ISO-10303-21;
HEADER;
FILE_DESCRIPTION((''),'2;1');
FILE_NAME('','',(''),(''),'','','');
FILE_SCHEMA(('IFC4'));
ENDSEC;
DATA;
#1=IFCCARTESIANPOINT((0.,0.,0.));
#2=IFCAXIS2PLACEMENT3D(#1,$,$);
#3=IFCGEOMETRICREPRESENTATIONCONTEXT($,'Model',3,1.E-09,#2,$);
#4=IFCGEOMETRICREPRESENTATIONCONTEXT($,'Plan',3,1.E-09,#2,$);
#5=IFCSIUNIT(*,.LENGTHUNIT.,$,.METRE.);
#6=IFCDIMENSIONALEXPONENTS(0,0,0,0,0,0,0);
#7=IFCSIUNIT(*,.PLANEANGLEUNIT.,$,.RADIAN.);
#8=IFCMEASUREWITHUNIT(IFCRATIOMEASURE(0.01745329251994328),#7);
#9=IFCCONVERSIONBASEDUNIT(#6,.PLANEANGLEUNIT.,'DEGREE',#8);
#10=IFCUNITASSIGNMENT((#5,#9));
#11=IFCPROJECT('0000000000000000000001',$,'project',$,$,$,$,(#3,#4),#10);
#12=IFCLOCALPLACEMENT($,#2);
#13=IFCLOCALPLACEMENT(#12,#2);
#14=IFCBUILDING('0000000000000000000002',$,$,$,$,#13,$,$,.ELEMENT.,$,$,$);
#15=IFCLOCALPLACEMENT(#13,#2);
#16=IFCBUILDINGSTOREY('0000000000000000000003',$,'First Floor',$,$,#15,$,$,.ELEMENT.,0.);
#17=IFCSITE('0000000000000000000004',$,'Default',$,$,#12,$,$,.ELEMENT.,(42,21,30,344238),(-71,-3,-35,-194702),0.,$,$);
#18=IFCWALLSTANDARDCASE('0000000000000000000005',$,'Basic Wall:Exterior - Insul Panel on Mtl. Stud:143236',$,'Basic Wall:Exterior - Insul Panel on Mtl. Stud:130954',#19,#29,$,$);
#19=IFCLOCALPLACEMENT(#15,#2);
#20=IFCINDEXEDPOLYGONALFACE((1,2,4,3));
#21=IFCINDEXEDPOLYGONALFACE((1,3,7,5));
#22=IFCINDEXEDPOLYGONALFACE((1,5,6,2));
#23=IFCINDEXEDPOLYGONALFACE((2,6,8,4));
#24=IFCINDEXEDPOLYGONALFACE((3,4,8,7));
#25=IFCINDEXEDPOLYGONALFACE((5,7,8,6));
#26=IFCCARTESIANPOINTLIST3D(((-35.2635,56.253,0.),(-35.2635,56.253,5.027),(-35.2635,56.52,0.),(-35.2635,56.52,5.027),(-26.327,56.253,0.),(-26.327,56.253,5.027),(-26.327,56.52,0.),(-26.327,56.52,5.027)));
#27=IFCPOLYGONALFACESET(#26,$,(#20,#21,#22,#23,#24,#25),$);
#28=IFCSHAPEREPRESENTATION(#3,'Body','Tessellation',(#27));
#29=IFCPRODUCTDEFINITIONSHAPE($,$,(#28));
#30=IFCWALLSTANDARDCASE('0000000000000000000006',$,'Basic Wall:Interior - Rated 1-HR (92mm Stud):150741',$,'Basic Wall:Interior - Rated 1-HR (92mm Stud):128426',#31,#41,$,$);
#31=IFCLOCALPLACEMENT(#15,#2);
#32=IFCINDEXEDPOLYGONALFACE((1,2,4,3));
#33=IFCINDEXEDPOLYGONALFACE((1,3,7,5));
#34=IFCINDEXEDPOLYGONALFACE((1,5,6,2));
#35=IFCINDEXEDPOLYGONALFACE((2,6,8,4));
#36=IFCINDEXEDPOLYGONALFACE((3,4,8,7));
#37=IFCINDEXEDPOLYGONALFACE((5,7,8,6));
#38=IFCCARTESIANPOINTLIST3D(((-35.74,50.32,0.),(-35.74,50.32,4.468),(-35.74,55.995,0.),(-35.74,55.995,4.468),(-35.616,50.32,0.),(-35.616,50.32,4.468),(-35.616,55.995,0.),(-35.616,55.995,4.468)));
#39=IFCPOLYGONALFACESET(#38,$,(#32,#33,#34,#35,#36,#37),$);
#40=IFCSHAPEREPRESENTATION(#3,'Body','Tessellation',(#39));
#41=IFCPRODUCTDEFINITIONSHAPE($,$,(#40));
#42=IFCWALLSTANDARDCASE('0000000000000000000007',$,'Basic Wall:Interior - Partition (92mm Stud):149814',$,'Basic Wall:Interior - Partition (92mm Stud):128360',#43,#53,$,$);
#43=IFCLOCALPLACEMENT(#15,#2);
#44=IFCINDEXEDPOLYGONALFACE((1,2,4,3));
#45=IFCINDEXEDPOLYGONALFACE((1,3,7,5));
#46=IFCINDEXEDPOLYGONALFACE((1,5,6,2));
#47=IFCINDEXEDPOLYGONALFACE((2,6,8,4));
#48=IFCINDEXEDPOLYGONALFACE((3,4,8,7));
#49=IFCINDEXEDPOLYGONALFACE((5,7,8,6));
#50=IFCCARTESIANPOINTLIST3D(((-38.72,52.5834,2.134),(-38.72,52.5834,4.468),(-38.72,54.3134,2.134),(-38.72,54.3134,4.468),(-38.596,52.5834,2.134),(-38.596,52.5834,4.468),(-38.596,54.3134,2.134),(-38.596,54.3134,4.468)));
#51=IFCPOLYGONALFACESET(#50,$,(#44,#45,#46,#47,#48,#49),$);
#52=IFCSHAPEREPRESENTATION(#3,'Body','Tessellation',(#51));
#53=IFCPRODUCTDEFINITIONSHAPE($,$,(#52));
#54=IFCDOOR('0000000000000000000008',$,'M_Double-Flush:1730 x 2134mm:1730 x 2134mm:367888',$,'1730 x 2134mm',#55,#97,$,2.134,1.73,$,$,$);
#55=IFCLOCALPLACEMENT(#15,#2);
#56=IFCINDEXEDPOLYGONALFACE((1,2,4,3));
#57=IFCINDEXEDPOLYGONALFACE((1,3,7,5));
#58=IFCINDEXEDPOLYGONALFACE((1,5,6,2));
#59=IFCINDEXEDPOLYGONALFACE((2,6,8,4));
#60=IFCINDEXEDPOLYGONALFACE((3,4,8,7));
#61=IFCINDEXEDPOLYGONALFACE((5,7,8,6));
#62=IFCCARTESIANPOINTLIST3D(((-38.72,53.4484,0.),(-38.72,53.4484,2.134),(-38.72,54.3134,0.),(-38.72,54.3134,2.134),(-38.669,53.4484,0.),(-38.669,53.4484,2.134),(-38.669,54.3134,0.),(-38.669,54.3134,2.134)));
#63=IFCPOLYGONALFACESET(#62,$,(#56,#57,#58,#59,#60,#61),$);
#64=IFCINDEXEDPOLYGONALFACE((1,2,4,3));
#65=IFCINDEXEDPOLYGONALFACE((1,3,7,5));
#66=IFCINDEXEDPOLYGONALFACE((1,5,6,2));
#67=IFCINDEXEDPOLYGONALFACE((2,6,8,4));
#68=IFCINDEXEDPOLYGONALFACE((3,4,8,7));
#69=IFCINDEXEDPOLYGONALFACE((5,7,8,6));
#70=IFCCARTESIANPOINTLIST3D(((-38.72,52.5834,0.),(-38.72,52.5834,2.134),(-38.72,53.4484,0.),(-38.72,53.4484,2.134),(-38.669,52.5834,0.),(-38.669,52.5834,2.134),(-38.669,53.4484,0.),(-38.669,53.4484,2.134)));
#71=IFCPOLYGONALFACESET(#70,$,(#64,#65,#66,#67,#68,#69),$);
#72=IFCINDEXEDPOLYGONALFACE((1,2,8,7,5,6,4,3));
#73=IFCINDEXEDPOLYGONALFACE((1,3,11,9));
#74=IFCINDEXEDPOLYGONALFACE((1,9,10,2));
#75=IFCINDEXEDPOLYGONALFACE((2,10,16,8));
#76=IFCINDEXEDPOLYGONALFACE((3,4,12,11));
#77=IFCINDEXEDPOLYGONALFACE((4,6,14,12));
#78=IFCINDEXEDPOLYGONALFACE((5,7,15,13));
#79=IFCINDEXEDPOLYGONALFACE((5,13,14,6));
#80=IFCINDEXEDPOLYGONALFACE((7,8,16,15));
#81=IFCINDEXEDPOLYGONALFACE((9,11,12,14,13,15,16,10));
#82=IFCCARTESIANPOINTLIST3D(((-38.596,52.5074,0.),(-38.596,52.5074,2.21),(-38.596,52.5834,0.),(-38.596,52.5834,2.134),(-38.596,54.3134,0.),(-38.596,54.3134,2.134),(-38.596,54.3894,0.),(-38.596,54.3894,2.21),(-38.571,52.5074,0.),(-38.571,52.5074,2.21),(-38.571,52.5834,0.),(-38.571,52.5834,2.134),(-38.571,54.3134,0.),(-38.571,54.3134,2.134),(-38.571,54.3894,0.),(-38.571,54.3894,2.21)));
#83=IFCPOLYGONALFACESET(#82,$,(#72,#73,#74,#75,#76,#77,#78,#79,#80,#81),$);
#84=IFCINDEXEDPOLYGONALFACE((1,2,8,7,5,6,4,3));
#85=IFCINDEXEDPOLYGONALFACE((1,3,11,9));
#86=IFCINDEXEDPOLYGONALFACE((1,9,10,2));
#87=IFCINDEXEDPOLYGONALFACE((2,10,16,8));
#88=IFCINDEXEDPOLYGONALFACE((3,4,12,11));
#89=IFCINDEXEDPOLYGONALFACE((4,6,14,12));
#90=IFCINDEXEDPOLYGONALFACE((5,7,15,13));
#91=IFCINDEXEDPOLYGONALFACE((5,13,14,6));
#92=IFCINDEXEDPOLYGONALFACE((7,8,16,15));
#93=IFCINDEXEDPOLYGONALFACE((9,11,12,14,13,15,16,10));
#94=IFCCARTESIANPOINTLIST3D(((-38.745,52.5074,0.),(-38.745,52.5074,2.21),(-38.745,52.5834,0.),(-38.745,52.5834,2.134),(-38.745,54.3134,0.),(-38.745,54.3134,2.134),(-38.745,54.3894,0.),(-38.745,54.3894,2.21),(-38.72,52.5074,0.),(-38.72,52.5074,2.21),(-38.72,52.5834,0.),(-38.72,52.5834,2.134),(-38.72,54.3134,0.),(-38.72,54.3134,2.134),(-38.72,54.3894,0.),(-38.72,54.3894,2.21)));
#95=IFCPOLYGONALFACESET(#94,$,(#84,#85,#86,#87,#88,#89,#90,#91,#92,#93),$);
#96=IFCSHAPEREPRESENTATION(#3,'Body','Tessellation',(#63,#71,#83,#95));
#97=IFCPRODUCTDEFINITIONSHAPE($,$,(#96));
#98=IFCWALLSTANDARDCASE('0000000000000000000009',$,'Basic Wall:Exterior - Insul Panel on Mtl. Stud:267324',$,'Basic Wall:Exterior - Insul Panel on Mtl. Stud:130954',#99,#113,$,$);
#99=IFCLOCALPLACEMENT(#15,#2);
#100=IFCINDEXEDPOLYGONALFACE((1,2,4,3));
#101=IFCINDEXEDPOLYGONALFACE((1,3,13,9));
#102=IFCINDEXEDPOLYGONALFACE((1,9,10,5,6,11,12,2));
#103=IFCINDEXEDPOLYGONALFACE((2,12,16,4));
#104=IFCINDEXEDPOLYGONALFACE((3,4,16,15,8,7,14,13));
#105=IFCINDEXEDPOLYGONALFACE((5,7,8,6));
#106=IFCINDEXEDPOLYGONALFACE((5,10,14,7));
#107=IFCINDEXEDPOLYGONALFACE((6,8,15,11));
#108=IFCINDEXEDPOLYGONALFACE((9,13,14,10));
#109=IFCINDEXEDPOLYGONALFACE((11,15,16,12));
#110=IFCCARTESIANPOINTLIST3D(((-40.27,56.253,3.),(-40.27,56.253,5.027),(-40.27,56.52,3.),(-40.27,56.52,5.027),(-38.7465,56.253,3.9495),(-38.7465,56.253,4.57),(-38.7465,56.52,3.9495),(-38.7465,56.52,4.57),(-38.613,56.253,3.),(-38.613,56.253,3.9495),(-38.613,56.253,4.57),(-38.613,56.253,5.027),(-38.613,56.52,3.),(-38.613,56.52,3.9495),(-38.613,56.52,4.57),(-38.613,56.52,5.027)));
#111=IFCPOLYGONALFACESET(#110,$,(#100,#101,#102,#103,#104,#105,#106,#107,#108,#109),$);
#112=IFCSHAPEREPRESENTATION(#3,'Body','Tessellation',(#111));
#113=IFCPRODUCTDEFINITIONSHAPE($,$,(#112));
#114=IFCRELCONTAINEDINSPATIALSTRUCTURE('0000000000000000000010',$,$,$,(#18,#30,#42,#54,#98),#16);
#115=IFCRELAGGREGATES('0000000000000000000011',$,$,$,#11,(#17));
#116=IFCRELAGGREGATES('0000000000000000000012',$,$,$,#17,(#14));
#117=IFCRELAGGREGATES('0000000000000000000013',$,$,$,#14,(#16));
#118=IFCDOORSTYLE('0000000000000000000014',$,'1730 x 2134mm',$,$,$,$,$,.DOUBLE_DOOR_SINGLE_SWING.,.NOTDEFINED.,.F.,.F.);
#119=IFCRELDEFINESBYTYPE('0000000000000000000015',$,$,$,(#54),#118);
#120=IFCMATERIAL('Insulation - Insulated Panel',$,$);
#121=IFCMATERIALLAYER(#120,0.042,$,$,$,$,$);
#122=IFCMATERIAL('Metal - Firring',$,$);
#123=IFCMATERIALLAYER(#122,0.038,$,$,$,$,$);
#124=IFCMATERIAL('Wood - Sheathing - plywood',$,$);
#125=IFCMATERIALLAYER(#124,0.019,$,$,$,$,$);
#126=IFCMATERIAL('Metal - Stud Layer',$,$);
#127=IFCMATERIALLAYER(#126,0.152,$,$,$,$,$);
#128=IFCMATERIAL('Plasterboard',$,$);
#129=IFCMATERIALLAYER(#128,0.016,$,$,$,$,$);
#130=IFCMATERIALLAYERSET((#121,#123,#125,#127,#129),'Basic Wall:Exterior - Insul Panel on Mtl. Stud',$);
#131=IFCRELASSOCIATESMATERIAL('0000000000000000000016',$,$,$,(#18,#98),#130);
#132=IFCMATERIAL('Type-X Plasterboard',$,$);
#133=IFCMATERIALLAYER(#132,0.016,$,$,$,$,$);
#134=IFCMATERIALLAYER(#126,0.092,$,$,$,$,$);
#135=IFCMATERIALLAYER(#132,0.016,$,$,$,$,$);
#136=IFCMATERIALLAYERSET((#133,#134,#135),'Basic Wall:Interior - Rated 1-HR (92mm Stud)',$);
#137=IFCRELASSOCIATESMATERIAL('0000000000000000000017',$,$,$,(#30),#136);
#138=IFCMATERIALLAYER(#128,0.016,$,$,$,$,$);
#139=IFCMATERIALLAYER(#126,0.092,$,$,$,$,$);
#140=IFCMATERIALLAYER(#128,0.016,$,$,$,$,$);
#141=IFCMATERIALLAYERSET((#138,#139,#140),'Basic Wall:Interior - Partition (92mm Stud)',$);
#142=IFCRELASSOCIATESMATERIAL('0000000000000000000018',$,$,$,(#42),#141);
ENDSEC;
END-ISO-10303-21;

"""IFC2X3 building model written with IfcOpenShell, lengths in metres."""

from ifc_helpers import new_model, entity, si_unit, converted_unit, frame, frame_2d, origin, origin_2d_with_axis, place, context, project, spatial, polyline, rectangle, outline, extrude, clip, bounded_halfspace, source, transform, mapped, material, layer, layer_set, layer_usage, type_object, type_shapes, element, fill, save


model = new_model("IFC2X3")

# Units and contexts
model_context = context("Model", 3, precision=1e-09, world=origin())
plan_context = context("Plan", 3, precision=1e-09, world=origin())
ifc_project = project(units=[si_unit("LENGTHUNIT", "METRE"), converted_unit("PLANEANGLEUNIT", "DEGREE", entity("IfcRatioMeasure", 0.01745329251994328), si_unit("PLANEANGLEUNIT", "RADIAN"), dimensions=[0, 0, 0, 0, 0, 0, 0])], contexts=[model_context, plan_context])

# Site, building, storey
site_placement = place(None, origin())
site = spatial("IfcSite", under=ifc_project, at=site_placement, Name="Default", CompositionType="ELEMENT", RefLatitude=(42, 21, 30, 344238), RefLongitude=(-71, -3, -35, -194702), RefElevation=0.0)
building_placement = place(site_placement, origin())
building = spatial("IfcBuilding", under=site, at=building_placement, CompositionType="ELEMENT")
storey_placement = place(building_placement, origin())
storey = spatial("IfcBuildingStorey", under=building, at=storey_placement, Name="First Floor", CompositionType="ELEMENT", Elevation=0.0)

# Walls
ifc_material_1 = material(Name="Insulation - Insulated Panel")
ifc_layer_1 = layer(ifc_material_1, 0.042)
ifc_material_2 = material(Name="Metal - Firring")
ifc_layer_2 = layer(ifc_material_2, 0.038)
ifc_material_3 = material(Name="Wood - Sheathing - plywood")
ifc_layer_3 = layer(ifc_material_3, 0.019)
ifc_material_4 = material(Name="Metal - Stud Layer")
ifc_layer_4 = layer(ifc_material_4, 0.152)
ifc_material_5 = material(Name="Plasterboard")
ifc_layer_5 = layer(ifc_material_5, 0.016)
ifc_layer_set_1 = layer_set([ifc_layer_1, ifc_layer_2, ifc_layer_3, ifc_layer_4, ifc_layer_5], Name="Basic Wall:Exterior - Insul Panel on Mtl. Stud")
ifc_layer_usage_1 = layer_usage(ifc_layer_set_1, "AXIS2", "NEGATIVE", 0.1335)
wall_1_placement = place(storey_placement, frame((-35.2635, 56.3865, 0.0)))
element("IfcWallStandardCase", 1, at=wall_1_placement, inside=storey, material=ifc_layer_usage_1, Name="Basic Wall:Exterior - Insul Panel on Mtl. Stud:143236", ObjectType="Basic Wall:Exterior - Insul Panel on Mtl. Stud:130954", context=model_context, shape_type="SweptSolid", body=[
    extrude(rectangle(XDim=8.9365, YDim=0.267, at=frame_2d((4.4682, 0.0), x_axis=(-1.0, 0.0))), origin(), (0.0, 0.0, 1.0), 5.027),
])
ifc_material_6 = material(Name="Type-X Plasterboard")
ifc_layer_6 = layer(ifc_material_6, 0.016)
ifc_layer_7 = layer(ifc_material_4, 0.092)
ifc_layer_8 = layer(ifc_material_6, 0.016)
ifc_layer_set_2 = layer_set([ifc_layer_6, ifc_layer_7, ifc_layer_8], Name="Basic Wall:Interior - Rated 1-HR (92mm Stud)")
ifc_layer_usage_2 = layer_usage(ifc_layer_set_2, "AXIS2", "NEGATIVE", 0.062)
wall_2_placement = place(storey_placement, frame((-35.678, 50.32, 0.0), z_axis=(0.0, 0.0, 1.0), x_axis=(0.0, 1.0, 0.0)))
element("IfcWallStandardCase", 2, at=wall_2_placement, inside=storey, material=ifc_layer_usage_2, Name="Basic Wall:Interior - Rated 1-HR (92mm Stud):150741", ObjectType="Basic Wall:Interior - Rated 1-HR (92mm Stud):128426", context=model_context, shape_type="SweptSolid", body=[
    extrude(rectangle(XDim=5.675, YDim=0.124, at=frame_2d((2.8375, 0.0), x_axis=(-1.0, 0.0))), origin(), (0.0, 0.0, 1.0), 4.468),
])

# Wall, opening, door
ifc_layer_9 = layer(ifc_material_5, 0.016)
ifc_layer_10 = layer(ifc_material_4, 0.092)
ifc_layer_11 = layer(ifc_material_5, 0.016)
ifc_layer_set_3 = layer_set([ifc_layer_9, ifc_layer_10, ifc_layer_11], Name="Basic Wall:Interior - Partition (92mm Stud)")
ifc_layer_usage_3 = layer_usage(ifc_layer_set_3, "AXIS2", "NEGATIVE", 0.062)
wall_3_placement = place(storey_placement, frame((-38.658, 54.3134, 0.0), z_axis=(0.0, 0.0, 1.0), x_axis=(0.0, -1.0, 0.0)))
wall_3 = element("IfcWallStandardCase", 3, at=wall_3_placement, inside=storey, material=ifc_layer_usage_3, Name="Basic Wall:Interior - Partition (92mm Stud):149814", ObjectType="Basic Wall:Interior - Partition (92mm Stud):128360", context=model_context, shape_type="SweptSolid", body=[
    extrude(rectangle(XDim=1.73, YDim=0.124, at=frame_2d((0.865, 0.0), x_axis=(-1.0, 0.0))), origin(), (0.0, 0.0, 1.0), 4.468),
])
opening_1_placement = place(wall_3_placement, frame((1.73, 0.062, 0.0)))
opening_1 = element("IfcOpeningElement", 4, at=opening_1_placement, cuts=wall_3, ObjectType="Opening", context=model_context, shape_type="SweptSolid", body=[
    extrude(rectangle(XDim=2.134, YDim=1.73, at=frame_2d((1.067, 0.865), x_axis=(1.0, 0.0))), frame((0.0, 0.0, 0.0), z_axis=(0.0, -1.0, 0.0), x_axis=(0.0, 0.0, 1.0)), (0.0, 0.0, 1.0), 0.124),
])
door_style_1 = type_object("IfcDoorStyle", Name="1730 x 2134mm", ConstructionType="NOTDEFINED", OperationType="DOUBLE_DOOR_SINGLE_SWING", ParameterTakesPrecedence=False, Sizeable=False)
shared_shape_1 = source(origin(), model_context, "Body", "SweptSolid", [
    extrude(rectangle(XDim=0.051, YDim=0.865, at=origin_2d_with_axis()), frame((1.2975, 0.0985, 0.0), z_axis=(0.0, 0.0, 1.0), x_axis=(0.0, -1.0, 0.0)), (0.0, 0.0, 1.0), 2.134),
    extrude(rectangle(XDim=0.051, YDim=0.865, at=origin_2d_with_axis()), frame((0.4325, 0.0985, 0.0), z_axis=(0.0, 0.0, 1.0), x_axis=(0.0, -1.0, 0.0)), (0.0, 0.0, 1.0), 2.134),
    extrude(outline(polyline([(-1.048, 0.865), (1.086, 0.865), (1.086, 0.941), (-1.124, 0.941), (-1.124, -0.941), (1.086, -0.941), (1.086, -0.865), (-1.048, -0.865), (-1.048, 0.865)])), frame((0.865, -0.025, 1.086), z_axis=(0.0, 1.0, 0.0), x_axis=(0.0, 0.0, -1.0)), (0.0, 0.0, 1.0), 0.025),
    extrude(outline(polyline([(-1.048, 0.865), (1.086, 0.865), (1.086, 0.941), (-1.124, 0.941), (-1.124, -0.941), (1.086, -0.941), (1.086, -0.865), (-1.048, -0.865), (-1.048, 0.865)])), frame((0.865, 0.124, 1.086), z_axis=(0.0, 1.0, 0.0), x_axis=(0.0, 0.0, -1.0)), (0.0, 0.0, 1.0), 0.025),
])
type_shapes(door_style_1, [shared_shape_1])
door_1_placement = place(opening_1_placement, frame((0.0, 0.0, 0.0), z_axis=(0.0, 0.0, 1.0), x_axis=(-1.0, 0.0, 0.0)))
door_1 = element("IfcDoor", 5, at=door_1_placement, inside=storey, type_object=door_style_1, Name="M_Double-Flush:1730 x 2134mm:1730 x 2134mm:367888", ObjectType="1730 x 2134mm", OverallHeight=2.134, OverallWidth=1.73, context=model_context, shape_type="MappedRepresentation", body=[
    mapped(shared_shape_1, transform((0.0, 0.0, 0.0), scale=1.0)),
])
fill(opening_1, door_1)

# Wall
wall_4_placement = place(storey_placement, frame((-40.4035, 56.3865, 3.0)))
element("IfcWallStandardCase", 6, at=wall_4_placement, inside=storey, material=ifc_layer_usage_1, Name="Basic Wall:Exterior - Insul Panel on Mtl. Stud:267324", ObjectType="Basic Wall:Exterior - Insul Panel on Mtl. Stud:130954", context=model_context, shape_type="Clipping", body=[
    clip(extrude(rectangle(XDim=1.657, YDim=0.267, at=frame_2d((0.962, 0.0), x_axis=(-1.0, 0.0))), origin(), (0.0, 0.0, 1.0), 2.027), bounded_halfspace(frame((1.657, -0.1335, 0.9495), z_axis=(-1.0, 0.0, 0.0), x_axis=(0.0, 1.0, 0.0)), True, frame((1.657, -0.1335, 0.9495), z_axis=(-1.0, 0.0, 0.0), x_axis=(0.0, 1.0, 0.0)), polyline([(0.0, 0.0), (0.0, -0.6205), (0.267, -0.6205), (0.267, 0.0), (0.0, 0.0)]))),
])

save(model, "model.ifc")
